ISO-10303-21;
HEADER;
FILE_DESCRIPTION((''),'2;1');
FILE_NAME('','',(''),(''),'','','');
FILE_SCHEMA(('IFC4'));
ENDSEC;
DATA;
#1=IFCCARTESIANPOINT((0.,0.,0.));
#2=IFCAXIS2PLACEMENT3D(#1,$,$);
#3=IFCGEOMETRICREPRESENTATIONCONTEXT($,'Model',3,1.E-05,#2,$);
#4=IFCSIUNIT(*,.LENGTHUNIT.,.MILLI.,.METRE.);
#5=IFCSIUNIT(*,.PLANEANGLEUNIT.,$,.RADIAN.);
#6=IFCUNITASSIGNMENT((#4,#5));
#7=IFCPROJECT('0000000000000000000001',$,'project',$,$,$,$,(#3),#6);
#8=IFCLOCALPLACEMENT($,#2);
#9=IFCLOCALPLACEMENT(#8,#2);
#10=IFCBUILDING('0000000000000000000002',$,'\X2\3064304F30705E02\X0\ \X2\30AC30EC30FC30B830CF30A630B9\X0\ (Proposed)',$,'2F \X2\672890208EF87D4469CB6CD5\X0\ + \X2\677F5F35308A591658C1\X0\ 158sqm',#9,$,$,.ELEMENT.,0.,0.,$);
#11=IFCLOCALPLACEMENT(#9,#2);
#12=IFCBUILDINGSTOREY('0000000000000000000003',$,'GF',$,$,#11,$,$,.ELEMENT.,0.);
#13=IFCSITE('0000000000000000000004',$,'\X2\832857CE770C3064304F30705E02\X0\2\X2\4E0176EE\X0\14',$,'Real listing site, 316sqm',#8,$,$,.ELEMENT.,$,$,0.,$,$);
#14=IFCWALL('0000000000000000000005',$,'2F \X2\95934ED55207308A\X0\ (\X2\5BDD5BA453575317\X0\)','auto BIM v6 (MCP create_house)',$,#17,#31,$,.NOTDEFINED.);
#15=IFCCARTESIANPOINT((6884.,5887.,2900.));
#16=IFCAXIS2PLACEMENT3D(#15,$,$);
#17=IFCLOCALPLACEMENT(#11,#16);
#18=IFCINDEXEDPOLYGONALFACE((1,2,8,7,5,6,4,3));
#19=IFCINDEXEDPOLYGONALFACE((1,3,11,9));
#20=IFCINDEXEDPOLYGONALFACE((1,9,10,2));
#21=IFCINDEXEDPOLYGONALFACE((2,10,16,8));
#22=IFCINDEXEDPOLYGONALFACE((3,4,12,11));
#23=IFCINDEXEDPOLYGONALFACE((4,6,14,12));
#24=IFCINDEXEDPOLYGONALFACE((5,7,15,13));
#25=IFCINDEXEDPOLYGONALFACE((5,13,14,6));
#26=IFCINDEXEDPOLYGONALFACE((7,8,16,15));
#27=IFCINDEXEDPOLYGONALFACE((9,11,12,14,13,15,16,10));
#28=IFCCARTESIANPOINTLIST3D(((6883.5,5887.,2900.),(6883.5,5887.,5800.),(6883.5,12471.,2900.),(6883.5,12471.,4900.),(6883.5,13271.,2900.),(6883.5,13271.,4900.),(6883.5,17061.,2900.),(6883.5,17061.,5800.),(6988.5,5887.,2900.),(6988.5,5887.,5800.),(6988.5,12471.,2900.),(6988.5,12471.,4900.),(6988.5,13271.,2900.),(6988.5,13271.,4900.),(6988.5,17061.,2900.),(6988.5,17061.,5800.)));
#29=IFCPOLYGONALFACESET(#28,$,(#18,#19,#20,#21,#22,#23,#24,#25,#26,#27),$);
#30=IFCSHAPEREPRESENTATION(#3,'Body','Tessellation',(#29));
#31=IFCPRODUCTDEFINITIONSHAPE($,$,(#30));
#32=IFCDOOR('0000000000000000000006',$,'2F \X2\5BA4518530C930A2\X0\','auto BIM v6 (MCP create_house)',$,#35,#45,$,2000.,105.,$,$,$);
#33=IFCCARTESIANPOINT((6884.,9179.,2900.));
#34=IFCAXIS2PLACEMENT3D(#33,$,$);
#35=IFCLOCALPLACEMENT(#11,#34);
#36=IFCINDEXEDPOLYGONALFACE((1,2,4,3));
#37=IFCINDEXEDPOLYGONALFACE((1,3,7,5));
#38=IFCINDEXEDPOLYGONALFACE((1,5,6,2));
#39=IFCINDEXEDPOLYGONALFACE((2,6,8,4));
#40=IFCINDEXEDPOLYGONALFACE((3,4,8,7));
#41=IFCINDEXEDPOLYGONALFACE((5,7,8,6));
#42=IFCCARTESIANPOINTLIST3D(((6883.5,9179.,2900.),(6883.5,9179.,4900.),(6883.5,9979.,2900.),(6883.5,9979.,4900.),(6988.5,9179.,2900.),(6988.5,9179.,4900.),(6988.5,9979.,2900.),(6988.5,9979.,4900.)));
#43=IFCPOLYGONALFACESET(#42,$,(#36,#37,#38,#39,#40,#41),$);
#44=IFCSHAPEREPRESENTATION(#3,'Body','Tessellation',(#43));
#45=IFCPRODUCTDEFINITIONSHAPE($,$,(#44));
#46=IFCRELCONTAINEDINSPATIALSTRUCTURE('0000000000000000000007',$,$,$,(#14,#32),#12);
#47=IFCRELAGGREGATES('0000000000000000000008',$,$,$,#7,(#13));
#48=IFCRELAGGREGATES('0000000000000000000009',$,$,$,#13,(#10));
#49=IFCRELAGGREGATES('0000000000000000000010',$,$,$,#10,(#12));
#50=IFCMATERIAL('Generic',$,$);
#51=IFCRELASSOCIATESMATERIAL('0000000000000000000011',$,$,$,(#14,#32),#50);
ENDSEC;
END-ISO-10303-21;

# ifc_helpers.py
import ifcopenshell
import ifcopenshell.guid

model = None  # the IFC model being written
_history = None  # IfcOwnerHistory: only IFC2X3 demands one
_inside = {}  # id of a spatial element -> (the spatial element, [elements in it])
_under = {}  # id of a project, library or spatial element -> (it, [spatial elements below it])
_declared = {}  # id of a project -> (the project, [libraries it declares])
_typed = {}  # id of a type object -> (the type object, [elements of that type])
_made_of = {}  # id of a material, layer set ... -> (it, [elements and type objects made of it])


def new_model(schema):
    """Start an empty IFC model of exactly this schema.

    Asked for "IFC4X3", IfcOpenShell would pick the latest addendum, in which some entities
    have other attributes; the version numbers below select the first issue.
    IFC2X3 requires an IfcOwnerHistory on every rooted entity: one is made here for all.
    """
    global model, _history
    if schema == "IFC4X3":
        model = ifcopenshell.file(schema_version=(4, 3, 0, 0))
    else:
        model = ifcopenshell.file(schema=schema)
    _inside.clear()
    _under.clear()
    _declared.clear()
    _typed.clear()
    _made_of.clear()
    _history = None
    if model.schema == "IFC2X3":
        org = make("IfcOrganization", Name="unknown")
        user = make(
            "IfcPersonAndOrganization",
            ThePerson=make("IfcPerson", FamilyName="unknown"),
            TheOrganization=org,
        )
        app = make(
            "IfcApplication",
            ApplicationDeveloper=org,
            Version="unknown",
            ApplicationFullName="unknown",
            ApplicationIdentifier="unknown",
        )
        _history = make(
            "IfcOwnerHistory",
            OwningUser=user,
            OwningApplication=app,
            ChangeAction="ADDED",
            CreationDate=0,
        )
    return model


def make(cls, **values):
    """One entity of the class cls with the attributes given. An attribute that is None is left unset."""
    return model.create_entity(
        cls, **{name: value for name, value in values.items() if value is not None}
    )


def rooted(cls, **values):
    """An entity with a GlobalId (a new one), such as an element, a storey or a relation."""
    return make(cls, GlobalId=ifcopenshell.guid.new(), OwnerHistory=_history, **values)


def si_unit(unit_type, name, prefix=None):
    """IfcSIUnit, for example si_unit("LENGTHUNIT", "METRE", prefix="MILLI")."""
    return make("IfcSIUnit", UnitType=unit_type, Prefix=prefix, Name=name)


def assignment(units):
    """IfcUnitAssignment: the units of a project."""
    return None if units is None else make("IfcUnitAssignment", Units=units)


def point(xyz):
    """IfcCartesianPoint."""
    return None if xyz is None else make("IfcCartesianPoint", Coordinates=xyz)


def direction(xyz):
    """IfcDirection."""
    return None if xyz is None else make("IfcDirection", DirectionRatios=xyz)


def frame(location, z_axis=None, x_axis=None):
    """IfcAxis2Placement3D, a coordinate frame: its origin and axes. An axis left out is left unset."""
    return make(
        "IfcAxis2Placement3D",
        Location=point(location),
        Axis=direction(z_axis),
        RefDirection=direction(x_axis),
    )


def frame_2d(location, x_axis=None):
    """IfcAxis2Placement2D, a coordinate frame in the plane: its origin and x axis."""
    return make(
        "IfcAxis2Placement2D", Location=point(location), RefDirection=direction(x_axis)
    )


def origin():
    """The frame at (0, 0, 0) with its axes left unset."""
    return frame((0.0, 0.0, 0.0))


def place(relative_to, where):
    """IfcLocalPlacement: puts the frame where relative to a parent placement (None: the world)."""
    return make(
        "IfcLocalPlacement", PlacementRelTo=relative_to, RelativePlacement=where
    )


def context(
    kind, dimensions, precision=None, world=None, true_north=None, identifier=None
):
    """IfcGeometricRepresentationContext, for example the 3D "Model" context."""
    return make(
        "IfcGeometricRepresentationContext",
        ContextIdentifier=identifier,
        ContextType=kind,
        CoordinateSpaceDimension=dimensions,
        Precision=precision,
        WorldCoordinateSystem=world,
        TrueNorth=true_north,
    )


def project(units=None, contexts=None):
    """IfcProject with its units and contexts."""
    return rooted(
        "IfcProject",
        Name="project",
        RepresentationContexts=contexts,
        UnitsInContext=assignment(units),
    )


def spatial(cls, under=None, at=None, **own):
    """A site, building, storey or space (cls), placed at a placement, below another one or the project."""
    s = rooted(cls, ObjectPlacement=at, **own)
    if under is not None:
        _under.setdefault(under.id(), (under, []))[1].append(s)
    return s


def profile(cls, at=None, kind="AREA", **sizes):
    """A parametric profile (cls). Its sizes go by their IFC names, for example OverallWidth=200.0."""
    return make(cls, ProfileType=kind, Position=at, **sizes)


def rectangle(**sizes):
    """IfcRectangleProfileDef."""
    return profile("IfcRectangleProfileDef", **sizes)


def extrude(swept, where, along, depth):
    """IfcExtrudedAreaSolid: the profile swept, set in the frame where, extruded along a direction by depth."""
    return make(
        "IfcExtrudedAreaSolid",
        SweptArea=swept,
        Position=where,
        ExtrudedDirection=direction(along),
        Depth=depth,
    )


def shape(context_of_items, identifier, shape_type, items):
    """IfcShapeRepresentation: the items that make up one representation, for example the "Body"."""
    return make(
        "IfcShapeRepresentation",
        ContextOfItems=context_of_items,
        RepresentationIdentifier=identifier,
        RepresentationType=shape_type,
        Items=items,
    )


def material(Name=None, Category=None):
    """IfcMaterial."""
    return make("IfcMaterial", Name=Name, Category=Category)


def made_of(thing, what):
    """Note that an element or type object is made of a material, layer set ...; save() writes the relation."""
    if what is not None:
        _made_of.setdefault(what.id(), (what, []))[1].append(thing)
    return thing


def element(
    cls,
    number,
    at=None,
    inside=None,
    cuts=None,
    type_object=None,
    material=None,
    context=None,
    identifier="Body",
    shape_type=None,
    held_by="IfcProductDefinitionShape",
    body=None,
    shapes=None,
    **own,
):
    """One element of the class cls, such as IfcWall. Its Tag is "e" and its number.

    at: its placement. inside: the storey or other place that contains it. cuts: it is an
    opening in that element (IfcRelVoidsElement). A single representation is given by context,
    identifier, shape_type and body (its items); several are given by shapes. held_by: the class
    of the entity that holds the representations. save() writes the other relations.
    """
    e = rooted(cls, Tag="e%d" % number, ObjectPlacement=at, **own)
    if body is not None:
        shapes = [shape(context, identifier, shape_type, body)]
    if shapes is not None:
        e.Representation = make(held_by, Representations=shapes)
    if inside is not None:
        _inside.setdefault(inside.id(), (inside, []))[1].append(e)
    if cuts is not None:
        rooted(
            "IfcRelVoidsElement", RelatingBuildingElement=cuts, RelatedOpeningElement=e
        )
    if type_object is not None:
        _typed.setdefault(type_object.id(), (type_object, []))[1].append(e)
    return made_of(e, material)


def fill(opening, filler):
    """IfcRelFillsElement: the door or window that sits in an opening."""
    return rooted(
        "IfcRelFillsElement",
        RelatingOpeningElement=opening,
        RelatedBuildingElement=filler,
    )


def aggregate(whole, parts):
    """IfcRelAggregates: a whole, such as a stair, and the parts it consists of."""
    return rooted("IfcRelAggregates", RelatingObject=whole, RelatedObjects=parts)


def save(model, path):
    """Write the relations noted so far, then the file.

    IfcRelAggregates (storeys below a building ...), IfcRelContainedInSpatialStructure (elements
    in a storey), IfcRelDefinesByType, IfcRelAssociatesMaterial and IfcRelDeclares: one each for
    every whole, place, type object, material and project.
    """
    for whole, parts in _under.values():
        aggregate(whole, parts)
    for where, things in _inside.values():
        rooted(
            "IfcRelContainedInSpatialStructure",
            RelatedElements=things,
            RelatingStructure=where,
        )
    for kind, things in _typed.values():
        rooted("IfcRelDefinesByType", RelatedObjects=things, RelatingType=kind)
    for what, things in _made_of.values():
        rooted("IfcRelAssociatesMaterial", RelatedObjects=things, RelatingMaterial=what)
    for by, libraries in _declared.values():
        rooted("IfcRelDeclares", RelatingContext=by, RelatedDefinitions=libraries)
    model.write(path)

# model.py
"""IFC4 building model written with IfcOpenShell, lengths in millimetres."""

from ifc_helpers import new_model, si_unit, frame, frame_2d, origin, place, context, project, spatial, rectangle, extrude, material, element, fill, save


model = new_model("IFC4")

# Units and contexts
model_context = context("Model", 3, precision=1e-05, world=origin())
ifc_project = project(units=[si_unit("LENGTHUNIT", "METRE", prefix="MILLI"), si_unit("PLANEANGLEUNIT", "RADIAN")], contexts=[model_context])

# Site, building, storey
site_placement = place(None, origin())
site = spatial("IfcSite", under=ifc_project, at=site_placement, Name="茨城県つくば市2丁目14", ObjectType="Real listing site, 316sqm", CompositionType="ELEMENT", RefElevation=0.0)
building_placement = place(site_placement, origin())
building = spatial("IfcBuilding", under=site, at=building_placement, Name="つくば市 ガレージハウス (Proposed)", ObjectType="2F 木造軸組構法 + 板張り外壁 158sqm", CompositionType="ELEMENT", ElevationOfRefHeight=0.0, ElevationOfTerrain=0.0)
storey_placement = place(building_placement, origin())
storey = spatial("IfcBuildingStorey", under=building, at=storey_placement, Name="GF", CompositionType="ELEMENT", Elevation=0.0)

# Shared definitions
ifc_material = material(Name="Generic")

# Wall, opening, door
wall_1_placement = place(storey_placement, frame((6884.0, 5887.0, 2900.0)))
wall_1 = element("IfcWall", 1, at=wall_1_placement, inside=storey, material=ifc_material, Name="2F 間仕切り (寝室南北)", Description="auto BIM v6 (MCP create_house)", PredefinedType="NOTDEFINED", context=model_context, shape_type="SweptSolid", body=[
    extrude(rectangle(XDim=105.0, YDim=11174.0, at=frame_2d((52.0, 5587.0))), frame((6884.0, 5887.0, 2900.0)), (0.0, 0.0, 1.0), 2900.0),
])
opening_1_placement = place(storey_placement, frame((6884.0, 9179.0, 2900.0)))
opening_1 = element("IfcOpeningElement", 2, at=opening_1_placement, cuts=wall_1, PredefinedType="NOTDEFINED", context=model_context, shape_type="SweptSolid", body=[
    extrude(rectangle(XDim=105.0, YDim=800.0, at=frame_2d((52.0, 400.0))), frame((6884.0, 9179.0, 2900.0)), (0.0, 0.0, 1.0), 2000.0),
])
door_placement = place(storey_placement, frame((6884.0, 9179.0, 2900.0)))
door = element("IfcDoor", 3, at=door_placement, inside=storey, material=ifc_material, Name="2F 室内ドア", Description="auto BIM v6 (MCP create_house)", OverallHeight=2000.0, OverallWidth=105.0, context=model_context, shape_type="SweptSolid", body=[
    extrude(rectangle(XDim=105.0, YDim=800.0, at=frame_2d((52.0, 400.0))), frame((6884.0, 9179.0, 2900.0)), (0.0, 0.0, 1.0), 2000.0),
])
fill(opening_1, door)

save(model, "model.ifc")
